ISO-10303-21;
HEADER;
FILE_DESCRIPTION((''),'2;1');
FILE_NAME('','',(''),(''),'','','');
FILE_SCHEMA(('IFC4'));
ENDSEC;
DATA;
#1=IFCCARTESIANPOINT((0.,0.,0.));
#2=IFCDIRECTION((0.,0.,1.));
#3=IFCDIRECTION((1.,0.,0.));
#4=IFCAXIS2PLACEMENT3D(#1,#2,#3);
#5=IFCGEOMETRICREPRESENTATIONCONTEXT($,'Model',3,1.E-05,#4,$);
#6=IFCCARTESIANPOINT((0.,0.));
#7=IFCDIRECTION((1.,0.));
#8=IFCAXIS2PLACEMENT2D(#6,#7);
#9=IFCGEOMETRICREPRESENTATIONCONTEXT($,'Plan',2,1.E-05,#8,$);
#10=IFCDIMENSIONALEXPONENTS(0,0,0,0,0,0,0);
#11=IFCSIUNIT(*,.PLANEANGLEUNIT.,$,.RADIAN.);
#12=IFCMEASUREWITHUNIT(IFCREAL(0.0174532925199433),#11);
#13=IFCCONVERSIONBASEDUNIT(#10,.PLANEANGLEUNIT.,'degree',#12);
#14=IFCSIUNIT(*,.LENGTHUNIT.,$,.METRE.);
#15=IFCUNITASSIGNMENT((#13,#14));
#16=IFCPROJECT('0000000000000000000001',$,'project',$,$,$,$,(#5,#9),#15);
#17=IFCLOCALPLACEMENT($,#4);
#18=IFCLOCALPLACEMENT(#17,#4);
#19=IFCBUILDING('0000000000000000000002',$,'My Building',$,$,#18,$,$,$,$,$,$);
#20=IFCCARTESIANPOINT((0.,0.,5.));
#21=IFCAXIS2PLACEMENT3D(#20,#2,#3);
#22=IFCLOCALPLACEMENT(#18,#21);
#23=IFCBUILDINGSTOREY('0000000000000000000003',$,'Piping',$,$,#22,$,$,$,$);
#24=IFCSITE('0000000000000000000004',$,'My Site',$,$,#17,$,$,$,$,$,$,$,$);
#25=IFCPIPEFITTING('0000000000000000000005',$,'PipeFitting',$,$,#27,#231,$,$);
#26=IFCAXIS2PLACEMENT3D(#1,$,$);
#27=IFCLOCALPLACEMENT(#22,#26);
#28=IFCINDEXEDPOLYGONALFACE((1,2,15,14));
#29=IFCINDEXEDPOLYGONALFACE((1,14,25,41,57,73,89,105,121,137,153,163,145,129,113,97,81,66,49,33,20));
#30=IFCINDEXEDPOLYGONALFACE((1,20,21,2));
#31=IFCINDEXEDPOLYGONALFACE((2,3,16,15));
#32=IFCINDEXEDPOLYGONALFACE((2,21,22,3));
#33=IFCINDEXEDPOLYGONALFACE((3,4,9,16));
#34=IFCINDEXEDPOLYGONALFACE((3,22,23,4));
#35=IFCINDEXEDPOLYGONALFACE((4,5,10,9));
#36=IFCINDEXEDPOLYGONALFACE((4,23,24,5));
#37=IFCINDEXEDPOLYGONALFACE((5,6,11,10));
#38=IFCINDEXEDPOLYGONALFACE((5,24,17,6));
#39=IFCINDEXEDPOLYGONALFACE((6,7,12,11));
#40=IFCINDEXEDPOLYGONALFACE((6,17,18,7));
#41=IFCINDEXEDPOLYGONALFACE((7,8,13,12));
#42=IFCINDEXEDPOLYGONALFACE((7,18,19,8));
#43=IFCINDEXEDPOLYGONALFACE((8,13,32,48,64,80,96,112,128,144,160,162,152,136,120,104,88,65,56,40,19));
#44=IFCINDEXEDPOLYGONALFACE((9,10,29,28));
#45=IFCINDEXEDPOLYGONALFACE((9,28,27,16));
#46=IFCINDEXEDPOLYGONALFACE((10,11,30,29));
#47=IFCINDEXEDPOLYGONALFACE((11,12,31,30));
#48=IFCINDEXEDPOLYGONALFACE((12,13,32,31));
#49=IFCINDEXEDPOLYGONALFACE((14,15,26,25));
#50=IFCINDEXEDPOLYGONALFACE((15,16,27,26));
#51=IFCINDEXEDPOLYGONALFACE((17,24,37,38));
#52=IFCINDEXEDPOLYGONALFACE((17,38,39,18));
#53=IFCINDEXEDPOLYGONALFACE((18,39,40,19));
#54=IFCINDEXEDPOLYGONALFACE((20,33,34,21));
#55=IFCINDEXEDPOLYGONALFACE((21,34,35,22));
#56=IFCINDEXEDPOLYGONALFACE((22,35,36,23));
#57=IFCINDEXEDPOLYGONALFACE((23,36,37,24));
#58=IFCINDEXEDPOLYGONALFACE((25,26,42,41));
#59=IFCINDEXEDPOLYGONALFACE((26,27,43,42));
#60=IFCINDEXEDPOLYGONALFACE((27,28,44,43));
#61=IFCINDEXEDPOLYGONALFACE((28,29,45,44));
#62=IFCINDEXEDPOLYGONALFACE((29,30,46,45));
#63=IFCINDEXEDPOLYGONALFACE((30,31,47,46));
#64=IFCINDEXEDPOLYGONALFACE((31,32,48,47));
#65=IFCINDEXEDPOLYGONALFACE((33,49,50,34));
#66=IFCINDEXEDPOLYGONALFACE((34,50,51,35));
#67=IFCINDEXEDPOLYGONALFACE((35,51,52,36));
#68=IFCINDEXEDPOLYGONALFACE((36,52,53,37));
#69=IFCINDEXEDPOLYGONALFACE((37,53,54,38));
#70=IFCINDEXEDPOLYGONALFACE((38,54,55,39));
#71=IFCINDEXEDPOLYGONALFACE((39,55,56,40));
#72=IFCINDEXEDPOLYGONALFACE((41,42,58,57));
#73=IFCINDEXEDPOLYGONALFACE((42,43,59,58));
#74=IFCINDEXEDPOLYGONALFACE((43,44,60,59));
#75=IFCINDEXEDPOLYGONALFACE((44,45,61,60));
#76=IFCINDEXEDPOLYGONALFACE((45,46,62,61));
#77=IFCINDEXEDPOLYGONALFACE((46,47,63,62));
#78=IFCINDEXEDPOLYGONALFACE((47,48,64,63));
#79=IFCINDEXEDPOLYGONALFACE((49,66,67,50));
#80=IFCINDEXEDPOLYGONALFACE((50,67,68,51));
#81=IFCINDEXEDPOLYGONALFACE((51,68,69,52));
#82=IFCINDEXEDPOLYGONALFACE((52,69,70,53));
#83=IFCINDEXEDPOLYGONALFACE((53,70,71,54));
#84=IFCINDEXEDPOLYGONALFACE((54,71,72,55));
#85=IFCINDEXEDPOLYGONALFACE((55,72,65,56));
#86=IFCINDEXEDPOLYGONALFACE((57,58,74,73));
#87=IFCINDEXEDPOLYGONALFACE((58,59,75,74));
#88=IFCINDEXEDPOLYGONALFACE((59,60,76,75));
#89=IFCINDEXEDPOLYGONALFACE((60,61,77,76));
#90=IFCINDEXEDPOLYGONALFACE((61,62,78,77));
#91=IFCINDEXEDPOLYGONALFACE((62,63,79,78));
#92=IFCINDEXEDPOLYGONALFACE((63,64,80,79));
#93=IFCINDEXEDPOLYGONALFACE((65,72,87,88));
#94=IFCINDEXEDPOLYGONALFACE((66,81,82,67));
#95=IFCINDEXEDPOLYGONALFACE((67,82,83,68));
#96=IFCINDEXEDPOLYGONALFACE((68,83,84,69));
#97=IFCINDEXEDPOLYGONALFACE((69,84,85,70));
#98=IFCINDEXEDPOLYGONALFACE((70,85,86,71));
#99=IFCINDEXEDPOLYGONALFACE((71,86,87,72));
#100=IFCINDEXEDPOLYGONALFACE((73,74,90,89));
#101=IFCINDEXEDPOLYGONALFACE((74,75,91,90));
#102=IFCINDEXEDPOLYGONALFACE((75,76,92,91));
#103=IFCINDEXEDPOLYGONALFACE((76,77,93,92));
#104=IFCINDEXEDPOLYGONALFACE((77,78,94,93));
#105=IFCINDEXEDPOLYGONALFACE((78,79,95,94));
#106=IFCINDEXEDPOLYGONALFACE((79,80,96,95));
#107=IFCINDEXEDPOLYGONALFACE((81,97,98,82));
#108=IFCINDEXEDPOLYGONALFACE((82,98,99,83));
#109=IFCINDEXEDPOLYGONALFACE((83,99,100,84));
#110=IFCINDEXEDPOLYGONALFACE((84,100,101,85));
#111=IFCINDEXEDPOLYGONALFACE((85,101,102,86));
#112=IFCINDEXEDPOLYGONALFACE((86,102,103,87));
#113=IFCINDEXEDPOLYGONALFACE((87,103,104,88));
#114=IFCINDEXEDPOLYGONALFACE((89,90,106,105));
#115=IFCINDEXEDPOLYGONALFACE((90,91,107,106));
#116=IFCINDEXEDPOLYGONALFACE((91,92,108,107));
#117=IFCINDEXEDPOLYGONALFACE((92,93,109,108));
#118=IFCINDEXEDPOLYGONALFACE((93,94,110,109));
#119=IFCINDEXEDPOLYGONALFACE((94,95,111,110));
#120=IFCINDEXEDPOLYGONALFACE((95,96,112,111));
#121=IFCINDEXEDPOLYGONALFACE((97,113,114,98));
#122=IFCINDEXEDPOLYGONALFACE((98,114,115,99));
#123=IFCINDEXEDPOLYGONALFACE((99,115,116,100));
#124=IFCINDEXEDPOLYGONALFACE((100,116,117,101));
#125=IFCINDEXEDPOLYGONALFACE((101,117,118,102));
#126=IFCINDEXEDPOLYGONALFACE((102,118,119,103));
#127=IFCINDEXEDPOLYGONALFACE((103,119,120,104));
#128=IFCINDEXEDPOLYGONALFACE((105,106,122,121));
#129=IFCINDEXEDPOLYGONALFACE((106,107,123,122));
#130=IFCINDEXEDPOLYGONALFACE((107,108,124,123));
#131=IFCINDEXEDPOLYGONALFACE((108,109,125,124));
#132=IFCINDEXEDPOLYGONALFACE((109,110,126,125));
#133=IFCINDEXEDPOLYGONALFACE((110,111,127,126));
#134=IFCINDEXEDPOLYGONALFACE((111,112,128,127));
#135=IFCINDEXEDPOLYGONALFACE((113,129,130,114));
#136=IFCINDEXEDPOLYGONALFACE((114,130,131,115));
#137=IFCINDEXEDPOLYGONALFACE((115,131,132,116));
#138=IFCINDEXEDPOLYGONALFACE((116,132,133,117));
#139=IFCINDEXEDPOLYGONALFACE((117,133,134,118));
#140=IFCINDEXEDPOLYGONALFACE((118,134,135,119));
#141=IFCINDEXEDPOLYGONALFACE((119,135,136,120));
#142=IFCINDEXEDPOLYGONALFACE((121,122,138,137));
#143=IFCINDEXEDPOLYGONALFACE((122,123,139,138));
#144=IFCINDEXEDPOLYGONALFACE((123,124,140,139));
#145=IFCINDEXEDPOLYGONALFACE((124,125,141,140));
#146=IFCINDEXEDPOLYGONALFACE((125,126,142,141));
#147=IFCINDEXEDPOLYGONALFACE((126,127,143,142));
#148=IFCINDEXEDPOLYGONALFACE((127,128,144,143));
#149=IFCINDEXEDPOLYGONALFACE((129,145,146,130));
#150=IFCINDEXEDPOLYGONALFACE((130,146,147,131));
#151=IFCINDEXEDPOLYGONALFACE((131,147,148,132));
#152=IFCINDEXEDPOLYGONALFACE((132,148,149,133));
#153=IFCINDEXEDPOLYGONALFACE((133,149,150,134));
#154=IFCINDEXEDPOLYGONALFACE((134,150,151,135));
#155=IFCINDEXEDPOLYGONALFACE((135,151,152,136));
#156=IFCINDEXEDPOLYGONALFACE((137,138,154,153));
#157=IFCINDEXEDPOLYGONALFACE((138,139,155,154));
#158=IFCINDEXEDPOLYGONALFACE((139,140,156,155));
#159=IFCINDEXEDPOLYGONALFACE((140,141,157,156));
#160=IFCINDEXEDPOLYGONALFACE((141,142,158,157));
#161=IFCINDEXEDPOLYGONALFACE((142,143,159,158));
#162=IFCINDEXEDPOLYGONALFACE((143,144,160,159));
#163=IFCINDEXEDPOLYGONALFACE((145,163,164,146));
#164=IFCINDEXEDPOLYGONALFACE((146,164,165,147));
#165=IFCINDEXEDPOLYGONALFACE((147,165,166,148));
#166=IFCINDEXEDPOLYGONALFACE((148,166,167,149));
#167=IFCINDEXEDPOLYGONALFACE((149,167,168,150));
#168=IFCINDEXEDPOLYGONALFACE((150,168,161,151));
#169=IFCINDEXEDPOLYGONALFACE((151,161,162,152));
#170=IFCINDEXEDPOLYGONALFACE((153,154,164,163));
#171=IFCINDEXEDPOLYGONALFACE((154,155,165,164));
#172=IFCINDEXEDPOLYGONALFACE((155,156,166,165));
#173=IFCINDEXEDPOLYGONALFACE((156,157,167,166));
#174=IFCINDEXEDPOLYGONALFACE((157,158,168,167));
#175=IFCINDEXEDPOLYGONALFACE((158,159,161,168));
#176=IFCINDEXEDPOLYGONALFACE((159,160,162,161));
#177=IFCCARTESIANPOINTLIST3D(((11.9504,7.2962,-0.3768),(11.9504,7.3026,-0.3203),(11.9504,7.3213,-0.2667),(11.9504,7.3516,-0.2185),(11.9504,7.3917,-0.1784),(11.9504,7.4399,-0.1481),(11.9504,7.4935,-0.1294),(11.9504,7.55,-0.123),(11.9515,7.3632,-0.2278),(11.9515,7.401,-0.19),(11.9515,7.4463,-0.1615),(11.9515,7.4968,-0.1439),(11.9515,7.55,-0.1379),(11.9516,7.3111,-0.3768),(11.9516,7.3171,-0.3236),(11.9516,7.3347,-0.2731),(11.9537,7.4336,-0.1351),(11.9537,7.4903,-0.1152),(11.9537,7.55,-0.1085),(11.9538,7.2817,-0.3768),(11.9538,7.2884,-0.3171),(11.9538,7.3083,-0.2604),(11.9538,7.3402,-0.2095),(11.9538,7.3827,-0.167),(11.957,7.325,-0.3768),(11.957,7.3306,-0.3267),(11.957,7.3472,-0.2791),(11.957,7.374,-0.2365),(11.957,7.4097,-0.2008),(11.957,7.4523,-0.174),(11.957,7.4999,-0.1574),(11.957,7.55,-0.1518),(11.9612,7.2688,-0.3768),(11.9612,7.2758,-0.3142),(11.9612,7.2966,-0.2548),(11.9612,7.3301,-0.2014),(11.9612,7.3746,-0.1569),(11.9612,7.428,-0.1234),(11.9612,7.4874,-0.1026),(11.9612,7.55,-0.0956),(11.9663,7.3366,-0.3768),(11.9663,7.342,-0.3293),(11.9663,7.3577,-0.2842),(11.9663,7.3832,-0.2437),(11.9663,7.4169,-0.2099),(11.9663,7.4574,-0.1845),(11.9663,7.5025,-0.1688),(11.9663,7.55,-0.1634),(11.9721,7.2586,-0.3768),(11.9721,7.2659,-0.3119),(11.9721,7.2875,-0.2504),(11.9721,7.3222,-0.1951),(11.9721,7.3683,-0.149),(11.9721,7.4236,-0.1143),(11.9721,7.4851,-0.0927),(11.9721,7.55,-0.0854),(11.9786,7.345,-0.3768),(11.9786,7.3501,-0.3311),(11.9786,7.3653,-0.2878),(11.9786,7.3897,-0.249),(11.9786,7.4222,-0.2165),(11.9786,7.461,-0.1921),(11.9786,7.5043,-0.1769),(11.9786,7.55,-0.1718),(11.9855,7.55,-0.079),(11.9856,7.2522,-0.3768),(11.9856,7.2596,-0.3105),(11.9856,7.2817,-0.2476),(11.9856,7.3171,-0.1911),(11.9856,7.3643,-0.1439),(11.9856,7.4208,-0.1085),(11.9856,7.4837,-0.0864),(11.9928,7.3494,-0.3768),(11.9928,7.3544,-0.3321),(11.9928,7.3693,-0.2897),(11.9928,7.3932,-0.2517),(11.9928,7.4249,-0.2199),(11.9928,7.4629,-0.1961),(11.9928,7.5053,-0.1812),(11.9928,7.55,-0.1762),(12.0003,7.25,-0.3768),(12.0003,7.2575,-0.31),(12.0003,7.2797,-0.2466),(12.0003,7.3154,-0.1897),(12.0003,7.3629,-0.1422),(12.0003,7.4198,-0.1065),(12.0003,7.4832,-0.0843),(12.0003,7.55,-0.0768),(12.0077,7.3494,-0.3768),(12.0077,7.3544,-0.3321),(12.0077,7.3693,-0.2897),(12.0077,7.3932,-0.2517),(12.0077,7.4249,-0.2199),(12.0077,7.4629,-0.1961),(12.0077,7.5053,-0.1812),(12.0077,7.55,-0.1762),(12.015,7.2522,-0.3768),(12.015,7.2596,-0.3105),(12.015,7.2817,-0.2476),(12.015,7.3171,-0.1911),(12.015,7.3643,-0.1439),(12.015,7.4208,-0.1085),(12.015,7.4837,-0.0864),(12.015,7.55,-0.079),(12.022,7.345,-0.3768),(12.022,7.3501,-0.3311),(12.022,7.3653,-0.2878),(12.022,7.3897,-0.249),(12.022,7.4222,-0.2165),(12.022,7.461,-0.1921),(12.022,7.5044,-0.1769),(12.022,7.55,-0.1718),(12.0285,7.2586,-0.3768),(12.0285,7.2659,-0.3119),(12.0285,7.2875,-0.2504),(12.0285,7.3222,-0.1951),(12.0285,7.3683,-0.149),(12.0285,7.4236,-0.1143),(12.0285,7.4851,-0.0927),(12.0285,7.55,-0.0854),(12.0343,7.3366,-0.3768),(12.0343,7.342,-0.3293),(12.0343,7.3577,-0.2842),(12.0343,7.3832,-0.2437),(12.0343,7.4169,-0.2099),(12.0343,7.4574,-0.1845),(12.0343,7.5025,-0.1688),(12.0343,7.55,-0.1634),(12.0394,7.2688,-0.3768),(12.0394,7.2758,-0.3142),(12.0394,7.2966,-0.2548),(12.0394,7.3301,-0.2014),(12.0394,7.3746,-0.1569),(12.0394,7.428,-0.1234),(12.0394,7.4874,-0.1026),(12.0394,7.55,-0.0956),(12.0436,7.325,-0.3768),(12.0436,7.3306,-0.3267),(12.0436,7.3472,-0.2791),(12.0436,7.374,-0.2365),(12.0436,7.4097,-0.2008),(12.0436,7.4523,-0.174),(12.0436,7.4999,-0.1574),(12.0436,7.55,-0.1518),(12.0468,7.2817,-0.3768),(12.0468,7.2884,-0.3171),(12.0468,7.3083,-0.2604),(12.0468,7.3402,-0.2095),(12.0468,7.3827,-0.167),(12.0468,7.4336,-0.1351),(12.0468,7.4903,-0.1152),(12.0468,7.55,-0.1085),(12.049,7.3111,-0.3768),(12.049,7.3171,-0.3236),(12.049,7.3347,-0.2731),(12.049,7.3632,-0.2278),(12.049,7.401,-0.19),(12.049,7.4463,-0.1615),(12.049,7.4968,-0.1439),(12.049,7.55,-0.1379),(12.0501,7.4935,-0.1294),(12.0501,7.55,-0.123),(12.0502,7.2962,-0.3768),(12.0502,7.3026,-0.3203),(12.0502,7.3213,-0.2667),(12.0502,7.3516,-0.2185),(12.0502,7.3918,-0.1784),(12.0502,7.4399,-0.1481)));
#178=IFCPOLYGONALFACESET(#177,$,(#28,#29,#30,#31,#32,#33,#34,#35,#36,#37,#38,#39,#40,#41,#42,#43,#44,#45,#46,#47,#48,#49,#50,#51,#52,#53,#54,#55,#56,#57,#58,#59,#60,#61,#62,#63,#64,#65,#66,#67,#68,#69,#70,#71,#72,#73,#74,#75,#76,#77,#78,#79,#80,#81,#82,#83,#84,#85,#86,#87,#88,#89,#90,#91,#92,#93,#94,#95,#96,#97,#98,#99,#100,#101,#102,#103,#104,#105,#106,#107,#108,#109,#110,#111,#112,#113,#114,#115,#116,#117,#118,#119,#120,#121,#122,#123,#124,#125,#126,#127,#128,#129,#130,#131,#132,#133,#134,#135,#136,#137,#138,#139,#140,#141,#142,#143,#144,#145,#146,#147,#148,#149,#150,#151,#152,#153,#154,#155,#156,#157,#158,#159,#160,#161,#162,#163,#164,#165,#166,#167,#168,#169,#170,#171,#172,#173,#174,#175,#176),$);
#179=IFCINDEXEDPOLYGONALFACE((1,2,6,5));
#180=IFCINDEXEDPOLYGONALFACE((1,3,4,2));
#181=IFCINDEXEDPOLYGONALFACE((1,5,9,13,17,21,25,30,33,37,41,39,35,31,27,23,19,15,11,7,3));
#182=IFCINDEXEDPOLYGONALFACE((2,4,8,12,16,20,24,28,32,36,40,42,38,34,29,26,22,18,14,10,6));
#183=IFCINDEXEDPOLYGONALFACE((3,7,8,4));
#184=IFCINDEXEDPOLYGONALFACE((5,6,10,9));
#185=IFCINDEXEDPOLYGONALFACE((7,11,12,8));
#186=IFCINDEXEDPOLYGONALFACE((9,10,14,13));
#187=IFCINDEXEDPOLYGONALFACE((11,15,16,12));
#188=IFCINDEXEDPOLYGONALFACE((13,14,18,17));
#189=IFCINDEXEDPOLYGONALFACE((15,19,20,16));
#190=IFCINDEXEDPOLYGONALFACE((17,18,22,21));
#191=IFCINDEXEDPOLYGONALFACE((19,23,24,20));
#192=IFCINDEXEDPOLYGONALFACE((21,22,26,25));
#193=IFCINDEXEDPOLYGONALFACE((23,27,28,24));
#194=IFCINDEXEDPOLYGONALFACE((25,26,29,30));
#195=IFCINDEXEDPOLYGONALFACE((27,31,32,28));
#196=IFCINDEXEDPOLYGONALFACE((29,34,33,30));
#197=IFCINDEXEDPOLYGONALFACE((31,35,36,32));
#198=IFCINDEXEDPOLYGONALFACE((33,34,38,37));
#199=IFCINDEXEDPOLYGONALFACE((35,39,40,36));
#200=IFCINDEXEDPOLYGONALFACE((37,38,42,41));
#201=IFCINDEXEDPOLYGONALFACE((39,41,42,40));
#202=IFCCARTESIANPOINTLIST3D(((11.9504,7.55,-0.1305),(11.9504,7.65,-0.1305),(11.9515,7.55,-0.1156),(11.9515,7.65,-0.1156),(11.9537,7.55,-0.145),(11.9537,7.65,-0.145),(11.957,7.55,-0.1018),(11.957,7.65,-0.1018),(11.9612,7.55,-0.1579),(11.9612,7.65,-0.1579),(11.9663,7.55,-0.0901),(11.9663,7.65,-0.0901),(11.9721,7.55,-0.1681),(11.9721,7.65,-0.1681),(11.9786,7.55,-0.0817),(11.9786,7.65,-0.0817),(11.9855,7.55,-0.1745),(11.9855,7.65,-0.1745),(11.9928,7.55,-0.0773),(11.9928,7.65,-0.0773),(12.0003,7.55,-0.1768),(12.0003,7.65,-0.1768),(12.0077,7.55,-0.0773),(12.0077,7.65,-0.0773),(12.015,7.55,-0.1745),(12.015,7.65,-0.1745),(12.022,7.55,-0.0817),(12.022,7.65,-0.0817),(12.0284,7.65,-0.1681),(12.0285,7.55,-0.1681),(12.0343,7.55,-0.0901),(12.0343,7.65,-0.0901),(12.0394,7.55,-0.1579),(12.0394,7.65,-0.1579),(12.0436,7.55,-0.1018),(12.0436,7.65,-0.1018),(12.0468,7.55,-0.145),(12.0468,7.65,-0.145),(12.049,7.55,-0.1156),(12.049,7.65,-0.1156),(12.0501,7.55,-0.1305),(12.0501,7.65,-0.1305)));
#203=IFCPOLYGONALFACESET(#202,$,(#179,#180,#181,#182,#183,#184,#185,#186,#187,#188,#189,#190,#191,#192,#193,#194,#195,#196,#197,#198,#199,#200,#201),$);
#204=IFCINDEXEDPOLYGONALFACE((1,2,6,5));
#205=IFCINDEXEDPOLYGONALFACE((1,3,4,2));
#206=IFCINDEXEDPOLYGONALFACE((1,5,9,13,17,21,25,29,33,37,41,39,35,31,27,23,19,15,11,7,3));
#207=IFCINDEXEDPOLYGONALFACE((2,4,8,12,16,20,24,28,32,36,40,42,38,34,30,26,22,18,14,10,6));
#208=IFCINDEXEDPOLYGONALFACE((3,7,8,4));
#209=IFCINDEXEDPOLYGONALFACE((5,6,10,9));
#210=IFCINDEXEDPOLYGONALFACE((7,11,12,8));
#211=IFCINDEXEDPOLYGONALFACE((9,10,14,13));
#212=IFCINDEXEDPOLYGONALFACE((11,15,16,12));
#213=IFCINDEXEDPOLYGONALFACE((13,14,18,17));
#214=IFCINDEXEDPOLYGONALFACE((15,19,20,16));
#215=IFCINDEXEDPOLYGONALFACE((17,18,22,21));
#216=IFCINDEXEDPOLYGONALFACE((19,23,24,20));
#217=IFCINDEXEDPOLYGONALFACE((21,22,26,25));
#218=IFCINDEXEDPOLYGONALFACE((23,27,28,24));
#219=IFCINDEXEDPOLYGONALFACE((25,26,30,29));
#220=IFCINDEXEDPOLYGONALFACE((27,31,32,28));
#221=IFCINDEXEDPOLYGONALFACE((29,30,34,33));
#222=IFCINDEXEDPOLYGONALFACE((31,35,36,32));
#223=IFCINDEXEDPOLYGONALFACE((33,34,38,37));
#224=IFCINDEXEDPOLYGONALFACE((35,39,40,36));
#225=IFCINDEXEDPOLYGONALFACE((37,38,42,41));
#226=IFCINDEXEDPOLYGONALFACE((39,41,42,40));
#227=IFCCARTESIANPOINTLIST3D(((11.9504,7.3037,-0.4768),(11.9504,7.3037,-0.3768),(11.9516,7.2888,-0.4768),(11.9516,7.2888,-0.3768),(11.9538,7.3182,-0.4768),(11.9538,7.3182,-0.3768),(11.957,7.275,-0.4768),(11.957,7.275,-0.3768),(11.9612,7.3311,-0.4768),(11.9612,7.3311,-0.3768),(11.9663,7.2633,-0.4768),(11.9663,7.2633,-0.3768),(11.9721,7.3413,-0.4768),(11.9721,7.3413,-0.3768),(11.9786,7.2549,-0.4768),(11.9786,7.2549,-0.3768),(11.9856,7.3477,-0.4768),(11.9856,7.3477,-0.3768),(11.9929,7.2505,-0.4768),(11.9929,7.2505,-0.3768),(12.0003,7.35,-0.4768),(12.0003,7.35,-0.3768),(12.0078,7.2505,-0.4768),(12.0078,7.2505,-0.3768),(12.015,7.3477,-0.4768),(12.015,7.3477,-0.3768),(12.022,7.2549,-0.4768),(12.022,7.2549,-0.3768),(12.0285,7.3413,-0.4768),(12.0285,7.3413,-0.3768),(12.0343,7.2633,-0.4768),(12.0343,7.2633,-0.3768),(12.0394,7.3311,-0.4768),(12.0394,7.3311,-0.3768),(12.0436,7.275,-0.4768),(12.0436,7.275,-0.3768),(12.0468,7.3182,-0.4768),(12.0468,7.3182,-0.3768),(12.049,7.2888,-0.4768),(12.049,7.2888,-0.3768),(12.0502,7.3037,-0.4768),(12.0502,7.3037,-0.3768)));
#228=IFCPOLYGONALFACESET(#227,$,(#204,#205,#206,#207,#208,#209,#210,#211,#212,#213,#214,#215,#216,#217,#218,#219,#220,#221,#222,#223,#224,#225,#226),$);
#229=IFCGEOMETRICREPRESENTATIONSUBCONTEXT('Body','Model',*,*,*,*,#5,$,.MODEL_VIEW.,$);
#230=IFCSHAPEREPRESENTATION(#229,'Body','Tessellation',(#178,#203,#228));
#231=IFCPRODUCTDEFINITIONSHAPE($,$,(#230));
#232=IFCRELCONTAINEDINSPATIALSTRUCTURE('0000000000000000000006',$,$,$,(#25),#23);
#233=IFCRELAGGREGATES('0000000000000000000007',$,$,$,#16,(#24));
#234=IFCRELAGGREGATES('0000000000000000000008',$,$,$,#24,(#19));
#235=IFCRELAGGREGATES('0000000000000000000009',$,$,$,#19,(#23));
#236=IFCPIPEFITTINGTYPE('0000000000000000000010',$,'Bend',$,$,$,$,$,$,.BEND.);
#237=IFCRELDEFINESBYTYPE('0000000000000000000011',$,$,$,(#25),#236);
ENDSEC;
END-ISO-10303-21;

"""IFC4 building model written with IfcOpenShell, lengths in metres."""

from ifc_helpers import new_model, entity, si_unit, converted_unit, frame, origin_with_axes, origin_2d_with_axis, place, context, subcontext, project, spatial, circle, extrude, source, transform, mapped, type_object, type_shapes, element, save


model = new_model("IFC4")

# Units and contexts
model_context = context("Model", 3, precision=1e-05, world=origin_with_axes())
plan_context = context("Plan", 2, precision=1e-05, world=origin_2d_with_axis())
body_context = subcontext(model_context, "Body", "Model", "MODEL_VIEW")
ifc_project = project(units=[converted_unit("PLANEANGLEUNIT", "degree", entity("IfcReal", 0.0174532925199433), si_unit("PLANEANGLEUNIT", "RADIAN"), dimensions=[0, 0, 0, 0, 0, 0, 0]), si_unit("LENGTHUNIT", "METRE")], contexts=[model_context, plan_context])

# Site, building, storey
site_placement = place(None, origin_with_axes())
site = spatial("IfcSite", under=ifc_project, at=site_placement, Name="My Site")
building_placement = place(site_placement, origin_with_axes())
building = spatial("IfcBuilding", under=site, at=building_placement, Name="My Building")
storey_placement = place(building_placement, frame((0.0, 0.0, 5.0), z_axis=(0.0, 0.0, 1.0), x_axis=(1.0, 0.0, 0.0)))
storey = spatial("IfcBuildingStorey", under=building, at=storey_placement, Name="Piping")

# Pipe fitting
pipe_fitting_type_1 = type_object("IfcPipeFittingType", Name="Bend", PredefinedType="BEND")
shared_shape = source(origin_with_axes(), body_context, "Body", "SolidModel", [
    entity("IfcSweptDiskSolid", entity("IfcIndexedPolyCurve", entity("IfcCartesianPointList3D", [[0.0, 0.0, -0.1], [0.0732, 0.0, -0.2768], [0.25, 0.0, -0.35]]), [entity("IfcArcIndex", [1, 2, 3])]), 0.05),
    extrude(circle(Radius=0.05), origin_with_axes(), (0.0, 0.0, -1.0), 0.1),
    extrude(circle(Radius=0.05), frame((0.25, 0.0, -0.35), z_axis=(1.0, 0.0, 0.0), x_axis=(0.0, 0.0, 1.0)), (0.0, 0.0, 1.0), 0.1),
])
type_shapes(pipe_fitting_type_1, [shared_shape])
for number, where, z_axis, x_axis, name in (
    (1, (12.0003, 7.65, -0.1268), (-0.00006, 1.0, 0.0), (0.0, 0.0, -1.0), "PipeFitting"),
):
    element("IfcPipeFitting", number, at=place(storey_placement, frame(where, z_axis=z_axis, x_axis=x_axis)), inside=storey, type_object=pipe_fitting_type_1, Name=name, context=body_context, shape_type="MappedRepresentation", body=[
        mapped(shared_shape, transform((0.0, 0.0, 0.0), x_axis=(1.0, 0.0, 0.0), y_axis=(0.0, 1.0, 0.0), z_axis=(0.0, 0.0, 1.0), scale=1.0)),
    ])

save(model, "model.ifc")
